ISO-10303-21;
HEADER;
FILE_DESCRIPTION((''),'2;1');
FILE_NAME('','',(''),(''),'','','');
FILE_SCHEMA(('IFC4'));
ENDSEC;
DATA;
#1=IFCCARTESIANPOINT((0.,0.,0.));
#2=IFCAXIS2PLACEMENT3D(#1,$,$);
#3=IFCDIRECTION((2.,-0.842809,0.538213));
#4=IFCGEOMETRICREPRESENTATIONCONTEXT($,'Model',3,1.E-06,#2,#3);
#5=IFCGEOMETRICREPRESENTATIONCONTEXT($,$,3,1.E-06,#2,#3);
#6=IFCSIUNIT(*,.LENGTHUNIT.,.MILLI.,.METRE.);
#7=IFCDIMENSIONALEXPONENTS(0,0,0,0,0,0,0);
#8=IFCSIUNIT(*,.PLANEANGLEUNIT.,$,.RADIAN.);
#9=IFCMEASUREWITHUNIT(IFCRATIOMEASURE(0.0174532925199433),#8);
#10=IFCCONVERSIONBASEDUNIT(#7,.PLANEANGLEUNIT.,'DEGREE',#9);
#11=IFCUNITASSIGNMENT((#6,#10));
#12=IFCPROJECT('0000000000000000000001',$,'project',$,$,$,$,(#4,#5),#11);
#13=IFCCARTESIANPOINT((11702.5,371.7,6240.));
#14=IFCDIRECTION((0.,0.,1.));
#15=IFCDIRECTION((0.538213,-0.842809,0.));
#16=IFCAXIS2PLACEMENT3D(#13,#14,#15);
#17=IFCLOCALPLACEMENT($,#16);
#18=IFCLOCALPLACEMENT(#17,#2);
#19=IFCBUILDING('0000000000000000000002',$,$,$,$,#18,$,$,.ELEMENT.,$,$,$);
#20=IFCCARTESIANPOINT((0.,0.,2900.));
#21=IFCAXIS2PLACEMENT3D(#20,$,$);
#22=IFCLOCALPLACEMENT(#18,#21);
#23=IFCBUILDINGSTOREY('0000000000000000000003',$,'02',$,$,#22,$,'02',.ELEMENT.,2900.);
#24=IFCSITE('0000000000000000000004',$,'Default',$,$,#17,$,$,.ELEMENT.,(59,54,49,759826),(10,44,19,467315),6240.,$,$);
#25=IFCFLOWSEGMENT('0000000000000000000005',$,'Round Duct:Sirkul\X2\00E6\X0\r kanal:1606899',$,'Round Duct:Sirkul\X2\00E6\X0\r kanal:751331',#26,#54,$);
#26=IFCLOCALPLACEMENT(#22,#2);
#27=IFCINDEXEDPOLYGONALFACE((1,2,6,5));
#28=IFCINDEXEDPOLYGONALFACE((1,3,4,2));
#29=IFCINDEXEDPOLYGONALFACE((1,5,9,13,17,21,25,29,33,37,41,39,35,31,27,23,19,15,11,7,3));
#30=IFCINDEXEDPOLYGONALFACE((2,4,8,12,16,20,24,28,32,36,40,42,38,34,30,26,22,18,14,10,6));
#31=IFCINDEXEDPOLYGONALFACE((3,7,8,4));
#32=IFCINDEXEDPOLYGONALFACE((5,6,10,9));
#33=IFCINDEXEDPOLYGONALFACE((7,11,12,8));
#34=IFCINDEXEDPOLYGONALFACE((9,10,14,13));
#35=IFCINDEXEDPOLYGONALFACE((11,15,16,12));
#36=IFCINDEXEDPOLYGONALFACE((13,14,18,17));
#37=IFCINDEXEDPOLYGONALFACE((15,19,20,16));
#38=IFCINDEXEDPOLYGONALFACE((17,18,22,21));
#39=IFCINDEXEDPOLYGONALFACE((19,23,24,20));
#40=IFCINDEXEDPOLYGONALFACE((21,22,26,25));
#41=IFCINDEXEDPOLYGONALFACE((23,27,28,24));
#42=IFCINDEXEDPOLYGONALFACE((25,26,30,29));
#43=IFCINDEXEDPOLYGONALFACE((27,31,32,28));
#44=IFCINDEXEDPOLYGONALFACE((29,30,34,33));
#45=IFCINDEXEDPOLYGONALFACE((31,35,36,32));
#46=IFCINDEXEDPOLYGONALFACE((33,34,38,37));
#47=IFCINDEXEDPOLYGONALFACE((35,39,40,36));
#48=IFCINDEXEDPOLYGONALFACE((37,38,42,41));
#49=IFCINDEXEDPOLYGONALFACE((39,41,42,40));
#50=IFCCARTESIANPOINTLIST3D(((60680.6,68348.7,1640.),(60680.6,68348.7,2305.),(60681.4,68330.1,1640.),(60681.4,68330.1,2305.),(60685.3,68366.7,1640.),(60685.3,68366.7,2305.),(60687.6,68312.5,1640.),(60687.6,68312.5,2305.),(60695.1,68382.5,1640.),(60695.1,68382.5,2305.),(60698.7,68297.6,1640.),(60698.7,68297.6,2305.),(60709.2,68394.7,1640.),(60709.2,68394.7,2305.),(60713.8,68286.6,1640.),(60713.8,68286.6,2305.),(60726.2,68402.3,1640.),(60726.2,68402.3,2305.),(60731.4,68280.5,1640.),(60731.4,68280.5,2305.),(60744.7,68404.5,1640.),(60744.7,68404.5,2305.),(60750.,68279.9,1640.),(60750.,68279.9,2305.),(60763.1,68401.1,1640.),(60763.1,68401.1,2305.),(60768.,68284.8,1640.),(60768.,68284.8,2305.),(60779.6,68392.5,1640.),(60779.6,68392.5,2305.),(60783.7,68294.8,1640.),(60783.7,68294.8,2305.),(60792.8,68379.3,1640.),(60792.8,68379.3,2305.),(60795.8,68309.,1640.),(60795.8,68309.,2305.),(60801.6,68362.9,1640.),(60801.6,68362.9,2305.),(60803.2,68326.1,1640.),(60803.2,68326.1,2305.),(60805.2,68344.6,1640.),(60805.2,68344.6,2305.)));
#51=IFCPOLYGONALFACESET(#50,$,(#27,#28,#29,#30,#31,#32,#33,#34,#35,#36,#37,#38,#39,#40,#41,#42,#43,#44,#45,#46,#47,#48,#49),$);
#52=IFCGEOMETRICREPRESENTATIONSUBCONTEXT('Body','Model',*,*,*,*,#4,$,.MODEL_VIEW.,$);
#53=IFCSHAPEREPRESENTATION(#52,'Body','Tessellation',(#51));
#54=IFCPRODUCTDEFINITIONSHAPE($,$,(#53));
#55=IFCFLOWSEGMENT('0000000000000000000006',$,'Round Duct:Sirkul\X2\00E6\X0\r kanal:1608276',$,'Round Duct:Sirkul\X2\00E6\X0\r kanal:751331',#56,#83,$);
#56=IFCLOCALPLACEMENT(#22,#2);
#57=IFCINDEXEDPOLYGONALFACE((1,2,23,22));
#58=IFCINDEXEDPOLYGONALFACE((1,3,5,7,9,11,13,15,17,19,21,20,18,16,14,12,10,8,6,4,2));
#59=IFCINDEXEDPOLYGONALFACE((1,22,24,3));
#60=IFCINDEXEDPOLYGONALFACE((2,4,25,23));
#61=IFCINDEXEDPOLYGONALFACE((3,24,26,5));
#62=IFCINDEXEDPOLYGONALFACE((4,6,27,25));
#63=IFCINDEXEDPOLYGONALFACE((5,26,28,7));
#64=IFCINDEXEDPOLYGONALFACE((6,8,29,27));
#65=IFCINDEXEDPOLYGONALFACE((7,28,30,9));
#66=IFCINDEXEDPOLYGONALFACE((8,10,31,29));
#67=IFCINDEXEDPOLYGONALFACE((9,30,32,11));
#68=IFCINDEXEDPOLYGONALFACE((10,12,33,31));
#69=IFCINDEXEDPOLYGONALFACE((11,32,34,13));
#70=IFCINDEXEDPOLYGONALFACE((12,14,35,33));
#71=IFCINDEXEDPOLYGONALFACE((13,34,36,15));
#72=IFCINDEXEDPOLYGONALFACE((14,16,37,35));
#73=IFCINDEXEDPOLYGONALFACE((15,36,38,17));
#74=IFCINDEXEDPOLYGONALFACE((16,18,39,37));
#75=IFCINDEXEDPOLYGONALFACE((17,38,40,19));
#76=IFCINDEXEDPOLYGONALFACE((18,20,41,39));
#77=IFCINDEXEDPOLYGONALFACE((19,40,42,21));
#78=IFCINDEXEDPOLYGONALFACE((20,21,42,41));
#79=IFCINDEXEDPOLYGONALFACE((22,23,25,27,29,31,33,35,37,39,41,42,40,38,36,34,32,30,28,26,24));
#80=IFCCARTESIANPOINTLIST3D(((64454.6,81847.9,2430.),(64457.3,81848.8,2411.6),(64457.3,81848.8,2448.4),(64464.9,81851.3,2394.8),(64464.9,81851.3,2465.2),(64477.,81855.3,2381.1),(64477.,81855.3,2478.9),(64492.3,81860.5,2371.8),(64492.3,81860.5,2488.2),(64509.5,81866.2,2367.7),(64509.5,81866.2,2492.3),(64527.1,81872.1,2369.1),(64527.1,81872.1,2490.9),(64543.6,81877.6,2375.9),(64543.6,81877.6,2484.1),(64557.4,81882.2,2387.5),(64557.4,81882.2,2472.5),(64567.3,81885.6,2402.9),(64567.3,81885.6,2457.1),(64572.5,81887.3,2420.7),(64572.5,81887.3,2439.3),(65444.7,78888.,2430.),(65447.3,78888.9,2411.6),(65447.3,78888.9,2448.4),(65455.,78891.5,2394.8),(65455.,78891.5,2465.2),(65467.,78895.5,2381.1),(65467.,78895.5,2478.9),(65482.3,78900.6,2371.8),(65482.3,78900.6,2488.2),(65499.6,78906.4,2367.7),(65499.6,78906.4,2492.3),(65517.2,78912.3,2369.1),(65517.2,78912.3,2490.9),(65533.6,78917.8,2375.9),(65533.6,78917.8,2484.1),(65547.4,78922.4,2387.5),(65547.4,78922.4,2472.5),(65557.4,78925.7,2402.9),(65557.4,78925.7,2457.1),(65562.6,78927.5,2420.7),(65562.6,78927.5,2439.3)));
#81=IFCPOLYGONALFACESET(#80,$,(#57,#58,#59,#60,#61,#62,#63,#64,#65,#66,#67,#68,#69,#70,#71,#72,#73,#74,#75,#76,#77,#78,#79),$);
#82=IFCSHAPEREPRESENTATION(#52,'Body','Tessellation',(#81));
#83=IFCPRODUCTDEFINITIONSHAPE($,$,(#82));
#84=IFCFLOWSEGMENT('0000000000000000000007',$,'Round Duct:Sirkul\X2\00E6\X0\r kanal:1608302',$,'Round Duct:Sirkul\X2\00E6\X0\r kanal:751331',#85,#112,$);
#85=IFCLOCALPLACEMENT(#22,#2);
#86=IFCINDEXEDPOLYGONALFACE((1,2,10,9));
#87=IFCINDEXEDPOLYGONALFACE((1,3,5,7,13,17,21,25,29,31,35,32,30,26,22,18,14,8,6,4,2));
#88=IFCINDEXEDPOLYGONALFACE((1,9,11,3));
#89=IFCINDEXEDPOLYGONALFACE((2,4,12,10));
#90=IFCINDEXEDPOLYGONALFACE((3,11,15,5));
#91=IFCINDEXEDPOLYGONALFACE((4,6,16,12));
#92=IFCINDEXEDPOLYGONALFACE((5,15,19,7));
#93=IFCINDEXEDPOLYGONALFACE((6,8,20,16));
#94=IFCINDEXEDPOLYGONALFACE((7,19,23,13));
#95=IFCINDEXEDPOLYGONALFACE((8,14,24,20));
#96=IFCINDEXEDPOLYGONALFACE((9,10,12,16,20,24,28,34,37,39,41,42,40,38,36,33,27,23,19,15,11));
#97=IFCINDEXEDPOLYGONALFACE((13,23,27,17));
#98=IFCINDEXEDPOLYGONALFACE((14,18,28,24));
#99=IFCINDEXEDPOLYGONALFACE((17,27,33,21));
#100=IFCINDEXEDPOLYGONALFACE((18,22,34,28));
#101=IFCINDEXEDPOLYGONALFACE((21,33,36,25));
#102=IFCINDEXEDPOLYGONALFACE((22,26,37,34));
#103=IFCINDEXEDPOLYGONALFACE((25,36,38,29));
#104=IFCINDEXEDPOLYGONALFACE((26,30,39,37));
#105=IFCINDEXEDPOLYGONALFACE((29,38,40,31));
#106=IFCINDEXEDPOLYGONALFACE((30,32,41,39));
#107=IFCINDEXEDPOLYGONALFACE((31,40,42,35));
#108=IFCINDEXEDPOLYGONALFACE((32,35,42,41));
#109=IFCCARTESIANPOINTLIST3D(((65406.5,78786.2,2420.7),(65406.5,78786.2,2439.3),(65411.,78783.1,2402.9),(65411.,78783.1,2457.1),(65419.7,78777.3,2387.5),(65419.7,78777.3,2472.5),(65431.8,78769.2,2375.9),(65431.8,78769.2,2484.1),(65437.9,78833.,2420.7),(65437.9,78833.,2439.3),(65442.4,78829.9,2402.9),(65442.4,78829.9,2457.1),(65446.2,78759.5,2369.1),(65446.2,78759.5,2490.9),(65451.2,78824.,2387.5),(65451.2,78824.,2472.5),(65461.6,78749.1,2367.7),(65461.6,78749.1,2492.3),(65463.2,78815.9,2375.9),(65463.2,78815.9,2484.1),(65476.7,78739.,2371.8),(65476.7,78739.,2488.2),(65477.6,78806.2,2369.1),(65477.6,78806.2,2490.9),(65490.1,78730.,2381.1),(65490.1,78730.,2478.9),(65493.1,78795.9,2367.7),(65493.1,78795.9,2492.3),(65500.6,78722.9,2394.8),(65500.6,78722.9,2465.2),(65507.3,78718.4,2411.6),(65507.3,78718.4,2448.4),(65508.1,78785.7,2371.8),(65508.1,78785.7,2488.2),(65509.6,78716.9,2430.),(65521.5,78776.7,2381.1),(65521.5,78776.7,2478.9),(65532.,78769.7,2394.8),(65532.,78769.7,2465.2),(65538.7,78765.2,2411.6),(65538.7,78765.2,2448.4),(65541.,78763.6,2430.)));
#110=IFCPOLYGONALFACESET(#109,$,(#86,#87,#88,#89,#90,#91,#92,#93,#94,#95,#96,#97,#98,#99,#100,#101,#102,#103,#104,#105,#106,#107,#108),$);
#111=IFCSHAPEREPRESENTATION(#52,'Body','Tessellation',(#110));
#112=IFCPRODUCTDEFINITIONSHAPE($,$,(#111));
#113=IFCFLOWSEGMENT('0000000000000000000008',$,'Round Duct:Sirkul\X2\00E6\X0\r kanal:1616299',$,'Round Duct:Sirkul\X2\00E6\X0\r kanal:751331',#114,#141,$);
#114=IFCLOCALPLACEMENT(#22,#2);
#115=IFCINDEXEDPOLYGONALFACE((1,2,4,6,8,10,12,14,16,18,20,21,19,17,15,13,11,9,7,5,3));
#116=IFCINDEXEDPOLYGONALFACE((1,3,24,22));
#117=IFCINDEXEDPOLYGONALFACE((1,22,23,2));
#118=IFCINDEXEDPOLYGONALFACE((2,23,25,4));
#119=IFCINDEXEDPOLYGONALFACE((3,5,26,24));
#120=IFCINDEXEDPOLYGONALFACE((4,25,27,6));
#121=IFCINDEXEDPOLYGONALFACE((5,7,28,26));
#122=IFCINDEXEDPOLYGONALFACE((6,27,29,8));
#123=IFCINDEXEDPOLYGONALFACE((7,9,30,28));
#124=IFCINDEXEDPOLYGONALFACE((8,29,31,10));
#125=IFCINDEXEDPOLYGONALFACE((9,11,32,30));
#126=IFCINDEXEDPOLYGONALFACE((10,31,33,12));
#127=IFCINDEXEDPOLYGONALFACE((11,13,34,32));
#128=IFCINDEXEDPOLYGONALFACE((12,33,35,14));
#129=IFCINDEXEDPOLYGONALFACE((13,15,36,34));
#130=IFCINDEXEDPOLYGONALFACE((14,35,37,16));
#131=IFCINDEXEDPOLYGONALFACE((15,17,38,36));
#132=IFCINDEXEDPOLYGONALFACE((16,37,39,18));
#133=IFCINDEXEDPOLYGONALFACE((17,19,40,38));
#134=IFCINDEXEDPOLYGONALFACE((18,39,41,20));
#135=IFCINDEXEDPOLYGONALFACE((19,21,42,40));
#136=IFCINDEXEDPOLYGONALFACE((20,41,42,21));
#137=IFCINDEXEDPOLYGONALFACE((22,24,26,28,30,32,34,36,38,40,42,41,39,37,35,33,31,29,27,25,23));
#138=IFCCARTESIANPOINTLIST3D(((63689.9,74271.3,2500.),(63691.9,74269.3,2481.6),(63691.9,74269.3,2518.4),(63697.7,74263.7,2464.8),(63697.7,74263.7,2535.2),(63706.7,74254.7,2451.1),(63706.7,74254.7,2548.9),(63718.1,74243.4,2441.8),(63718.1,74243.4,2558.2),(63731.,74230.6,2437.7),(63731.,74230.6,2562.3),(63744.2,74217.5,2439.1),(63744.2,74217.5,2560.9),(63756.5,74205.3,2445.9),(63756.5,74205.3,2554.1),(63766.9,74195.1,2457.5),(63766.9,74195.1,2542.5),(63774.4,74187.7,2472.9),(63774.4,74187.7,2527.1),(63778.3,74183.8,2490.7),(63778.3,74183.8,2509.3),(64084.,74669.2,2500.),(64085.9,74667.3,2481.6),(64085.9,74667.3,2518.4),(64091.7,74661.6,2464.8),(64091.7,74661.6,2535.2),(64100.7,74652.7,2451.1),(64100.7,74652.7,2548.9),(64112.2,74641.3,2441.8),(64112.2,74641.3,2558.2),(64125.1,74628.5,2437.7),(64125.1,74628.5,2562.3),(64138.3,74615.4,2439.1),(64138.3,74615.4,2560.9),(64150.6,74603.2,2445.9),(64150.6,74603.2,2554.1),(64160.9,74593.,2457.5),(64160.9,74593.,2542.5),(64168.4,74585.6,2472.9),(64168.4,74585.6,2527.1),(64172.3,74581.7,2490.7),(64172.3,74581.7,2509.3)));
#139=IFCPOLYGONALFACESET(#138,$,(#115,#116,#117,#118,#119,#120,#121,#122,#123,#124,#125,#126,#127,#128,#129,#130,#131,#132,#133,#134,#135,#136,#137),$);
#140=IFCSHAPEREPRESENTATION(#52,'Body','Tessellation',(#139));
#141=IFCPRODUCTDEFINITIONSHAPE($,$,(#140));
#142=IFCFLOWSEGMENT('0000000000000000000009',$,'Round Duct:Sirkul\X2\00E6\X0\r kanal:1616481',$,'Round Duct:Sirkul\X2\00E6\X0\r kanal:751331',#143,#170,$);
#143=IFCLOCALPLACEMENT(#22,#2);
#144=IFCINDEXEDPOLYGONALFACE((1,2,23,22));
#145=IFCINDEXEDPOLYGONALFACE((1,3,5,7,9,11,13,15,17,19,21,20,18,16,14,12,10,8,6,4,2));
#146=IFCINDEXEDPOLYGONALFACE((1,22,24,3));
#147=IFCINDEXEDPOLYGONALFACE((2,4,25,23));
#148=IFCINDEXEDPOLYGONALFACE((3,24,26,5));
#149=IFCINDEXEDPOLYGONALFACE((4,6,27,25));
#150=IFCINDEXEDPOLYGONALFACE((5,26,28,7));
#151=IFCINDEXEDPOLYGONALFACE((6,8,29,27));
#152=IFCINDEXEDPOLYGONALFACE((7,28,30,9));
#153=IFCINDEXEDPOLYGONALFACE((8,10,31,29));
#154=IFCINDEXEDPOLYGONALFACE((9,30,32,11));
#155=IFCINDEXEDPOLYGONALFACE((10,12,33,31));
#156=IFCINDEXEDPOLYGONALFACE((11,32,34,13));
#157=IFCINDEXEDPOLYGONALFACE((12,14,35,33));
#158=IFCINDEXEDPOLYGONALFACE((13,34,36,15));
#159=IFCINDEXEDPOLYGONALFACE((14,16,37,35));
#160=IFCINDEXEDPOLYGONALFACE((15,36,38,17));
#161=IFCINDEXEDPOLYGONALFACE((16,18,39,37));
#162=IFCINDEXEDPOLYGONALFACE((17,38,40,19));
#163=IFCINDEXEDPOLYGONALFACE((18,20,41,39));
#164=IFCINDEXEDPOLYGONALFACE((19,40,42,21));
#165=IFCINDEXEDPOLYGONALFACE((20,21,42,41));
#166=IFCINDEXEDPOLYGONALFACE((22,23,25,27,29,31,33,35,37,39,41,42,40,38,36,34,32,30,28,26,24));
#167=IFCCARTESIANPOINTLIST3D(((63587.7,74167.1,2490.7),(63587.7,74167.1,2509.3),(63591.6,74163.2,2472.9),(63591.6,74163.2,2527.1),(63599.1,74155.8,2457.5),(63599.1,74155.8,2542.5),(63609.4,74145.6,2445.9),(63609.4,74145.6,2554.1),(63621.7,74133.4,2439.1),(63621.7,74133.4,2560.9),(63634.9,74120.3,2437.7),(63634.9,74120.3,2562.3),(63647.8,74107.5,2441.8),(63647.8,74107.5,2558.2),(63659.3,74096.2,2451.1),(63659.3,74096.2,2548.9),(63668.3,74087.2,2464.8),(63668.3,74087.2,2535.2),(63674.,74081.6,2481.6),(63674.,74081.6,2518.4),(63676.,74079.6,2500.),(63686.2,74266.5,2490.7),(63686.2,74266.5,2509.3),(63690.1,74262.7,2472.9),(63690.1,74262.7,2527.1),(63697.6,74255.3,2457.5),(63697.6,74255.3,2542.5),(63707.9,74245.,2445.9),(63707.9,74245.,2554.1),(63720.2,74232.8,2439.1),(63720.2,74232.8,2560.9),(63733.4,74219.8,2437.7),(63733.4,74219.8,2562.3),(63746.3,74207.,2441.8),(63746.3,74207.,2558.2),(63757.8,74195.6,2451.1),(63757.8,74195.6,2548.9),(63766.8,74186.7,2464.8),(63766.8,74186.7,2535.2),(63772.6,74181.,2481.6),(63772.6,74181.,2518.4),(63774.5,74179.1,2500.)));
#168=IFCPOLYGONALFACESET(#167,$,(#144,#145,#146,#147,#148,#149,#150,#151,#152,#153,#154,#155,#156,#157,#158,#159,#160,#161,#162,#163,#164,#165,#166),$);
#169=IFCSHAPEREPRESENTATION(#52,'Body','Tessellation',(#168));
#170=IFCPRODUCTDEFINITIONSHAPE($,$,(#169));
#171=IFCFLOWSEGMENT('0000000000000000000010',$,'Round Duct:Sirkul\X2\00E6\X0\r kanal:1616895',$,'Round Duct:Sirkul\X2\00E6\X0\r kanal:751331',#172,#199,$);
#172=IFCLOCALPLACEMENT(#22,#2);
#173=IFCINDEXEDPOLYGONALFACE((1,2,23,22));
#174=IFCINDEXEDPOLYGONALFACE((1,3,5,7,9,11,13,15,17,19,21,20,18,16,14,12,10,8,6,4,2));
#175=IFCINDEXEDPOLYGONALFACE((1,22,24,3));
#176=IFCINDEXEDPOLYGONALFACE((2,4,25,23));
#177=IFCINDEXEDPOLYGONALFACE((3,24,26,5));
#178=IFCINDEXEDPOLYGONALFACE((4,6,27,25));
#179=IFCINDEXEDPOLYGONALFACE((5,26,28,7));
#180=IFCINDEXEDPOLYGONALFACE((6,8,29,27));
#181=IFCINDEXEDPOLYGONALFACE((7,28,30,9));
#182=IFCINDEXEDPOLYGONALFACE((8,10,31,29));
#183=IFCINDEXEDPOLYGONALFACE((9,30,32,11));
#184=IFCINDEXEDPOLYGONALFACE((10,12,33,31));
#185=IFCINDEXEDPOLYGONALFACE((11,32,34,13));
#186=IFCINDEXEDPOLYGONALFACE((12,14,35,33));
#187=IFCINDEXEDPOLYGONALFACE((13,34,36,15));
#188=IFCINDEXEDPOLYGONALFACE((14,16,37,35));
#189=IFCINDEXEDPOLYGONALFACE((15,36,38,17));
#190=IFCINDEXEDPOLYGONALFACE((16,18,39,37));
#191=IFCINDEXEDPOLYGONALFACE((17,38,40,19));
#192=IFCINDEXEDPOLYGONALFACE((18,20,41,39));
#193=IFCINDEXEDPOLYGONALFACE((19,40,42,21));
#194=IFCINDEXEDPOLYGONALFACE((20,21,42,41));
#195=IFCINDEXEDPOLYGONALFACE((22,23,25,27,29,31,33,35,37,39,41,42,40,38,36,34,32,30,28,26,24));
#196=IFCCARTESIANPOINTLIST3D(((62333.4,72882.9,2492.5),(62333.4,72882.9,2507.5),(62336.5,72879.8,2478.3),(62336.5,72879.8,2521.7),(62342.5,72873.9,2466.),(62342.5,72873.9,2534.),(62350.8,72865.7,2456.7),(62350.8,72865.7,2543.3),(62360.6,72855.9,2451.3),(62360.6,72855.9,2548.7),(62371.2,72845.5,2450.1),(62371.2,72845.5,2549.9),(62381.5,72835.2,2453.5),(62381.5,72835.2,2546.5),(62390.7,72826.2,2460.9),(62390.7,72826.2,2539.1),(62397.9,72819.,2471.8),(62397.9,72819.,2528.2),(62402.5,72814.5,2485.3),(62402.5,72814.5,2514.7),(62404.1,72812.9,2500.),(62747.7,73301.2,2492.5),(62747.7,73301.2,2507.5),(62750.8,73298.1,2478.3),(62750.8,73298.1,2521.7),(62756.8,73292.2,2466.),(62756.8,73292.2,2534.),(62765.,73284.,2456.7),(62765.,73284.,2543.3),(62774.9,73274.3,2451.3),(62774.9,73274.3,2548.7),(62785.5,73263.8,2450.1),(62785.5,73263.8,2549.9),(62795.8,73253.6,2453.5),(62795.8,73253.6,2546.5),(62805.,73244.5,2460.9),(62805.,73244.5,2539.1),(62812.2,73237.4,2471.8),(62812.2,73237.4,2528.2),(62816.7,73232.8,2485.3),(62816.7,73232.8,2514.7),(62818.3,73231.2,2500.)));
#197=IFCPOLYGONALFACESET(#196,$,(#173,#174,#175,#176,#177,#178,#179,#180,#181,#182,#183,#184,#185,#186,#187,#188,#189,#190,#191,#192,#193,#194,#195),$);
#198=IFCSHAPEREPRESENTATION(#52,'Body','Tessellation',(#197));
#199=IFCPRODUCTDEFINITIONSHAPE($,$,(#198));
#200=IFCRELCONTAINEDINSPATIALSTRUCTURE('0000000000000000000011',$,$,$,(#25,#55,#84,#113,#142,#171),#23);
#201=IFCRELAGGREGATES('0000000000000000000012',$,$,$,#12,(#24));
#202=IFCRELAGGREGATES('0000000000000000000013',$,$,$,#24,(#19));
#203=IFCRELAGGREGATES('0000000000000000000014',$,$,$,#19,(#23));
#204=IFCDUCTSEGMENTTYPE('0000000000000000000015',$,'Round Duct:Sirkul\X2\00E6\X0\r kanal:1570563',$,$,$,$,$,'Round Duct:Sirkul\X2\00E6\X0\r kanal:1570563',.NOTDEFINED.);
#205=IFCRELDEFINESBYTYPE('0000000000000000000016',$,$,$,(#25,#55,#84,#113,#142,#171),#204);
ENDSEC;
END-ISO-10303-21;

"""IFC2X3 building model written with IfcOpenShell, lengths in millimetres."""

from ifc_helpers import new_model, entity, si_unit, converted_unit, direction, frame, frame_2d, origin, origin_2d_with_axis, place, context, subcontext, project, spatial, circle, extrude, type_object, element, save


model = new_model("IFC2X3")

# Units and contexts
model_context = context("Model", 3, precision=1e-06, world=origin(), true_north=direction((2.0, -0.842809, 0.538213)))
context_of_model = context(None, 3, precision=1e-06, world=origin(), true_north=direction((2.0, -0.842809, 0.538213)))
body_context = subcontext(model_context, "Body", "Model", "MODEL_VIEW")
ifc_project = project(units=[si_unit("LENGTHUNIT", "METRE", prefix="MILLI"), converted_unit("PLANEANGLEUNIT", "DEGREE", entity("IfcRatioMeasure", 0.0174532925199433), si_unit("PLANEANGLEUNIT", "RADIAN"), dimensions=[0, 0, 0, 0, 0, 0, 0])], contexts=[model_context, context_of_model])

# Site, building, storey
site_placement = place(None, frame((11702.5, 371.7, 6240.0), z_axis=(0.0, 0.0, 1.0), x_axis=(0.538213, -0.842809, 0.0)))
site = spatial("IfcSite", under=ifc_project, at=site_placement, Name="Default", CompositionType="ELEMENT", RefLatitude=(59, 54, 49, 759826), RefLongitude=(10, 44, 19, 467315), RefElevation=6240.0)
building_placement = place(site_placement, origin())
building = spatial("IfcBuilding", under=site, at=building_placement, CompositionType="ELEMENT")
storey_placement = place(building_placement, frame((0.0, 0.0, 2900.0)))
storey = spatial("IfcBuildingStorey", under=building, at=storey_placement, Name="02", LongName="02", CompositionType="ELEMENT", Elevation=2900.0)

# Flow segments
duct_segment_type = type_object("IfcDuctSegmentType", Name="Round Duct:Sirkulær kanal:1570563", ElementType="Round Duct:Sirkulær kanal:1570563", PredefinedType="NOTDEFINED")
flow_segment_1_placement = place(storey_placement, origin())
element("IfcFlowSegment", 1, at=flow_segment_1_placement, inside=storey, type_object=duct_segment_type, Name="Round Duct:Sirkulær kanal:1606899", ObjectType="Round Duct:Sirkulær kanal:751331", context=body_context, shape_type="SweptSolid", body=[
    extrude(circle(Radius=62.5, at=origin_2d_with_axis()), frame((60742.7, 68342.0, 1640.0), z_axis=(0.0, 0.0, 1.0), x_axis=(-0.703661, -0.710536, 0.0)), (0.0, 0.0, 1.0), 665.0),
])
flow_segment_2_placement = place(storey_placement, origin())
element("IfcFlowSegment", 2, at=flow_segment_2_placement, inside=storey, type_object=duct_segment_type, Name="Round Duct:Sirkulær kanal:1608276", ObjectType="Round Duct:Sirkulær kanal:751331", context=body_context, shape_type="SweptSolid", body=[
    extrude(circle(Radius=62.5, at=origin_2d_with_axis()), frame((64513.9, 81867.7, 2430.0), z_axis=(0.317224, -0.948351, 0.0), x_axis=(-0.948351, -0.317224, 0.0)), (0.0, 0.0, 1.0), 3121.0),
])
flow_segment_3_placement = place(storey_placement, origin())
element("IfcFlowSegment", 3, at=flow_segment_3_placement, inside=storey, type_object=duct_segment_type, Name="Round Duct:Sirkulær kanal:1608302", ObjectType="Round Duct:Sirkulær kanal:751331", context=body_context, shape_type="SweptSolid", body=[
    extrude(circle(Radius=62.5, at=origin_2d_with_axis()), frame((65457.8, 78751.7, 2430.0), z_axis=(0.557892, 0.829913, 0.0), x_axis=(0.829913, -0.557892, 0.0)), (0.0, 0.0, 1.0), 56.3),
])
flow_segment_4_placement = place(storey_placement, origin())
element("IfcFlowSegment", 4, at=flow_segment_4_placement, inside=storey, type_object=duct_segment_type, Name="Round Duct:Sirkulær kanal:1616299", ObjectType="Round Duct:Sirkulær kanal:751331", context=body_context, shape_type="SweptSolid", body=[
    extrude(circle(Radius=62.5, at=origin_2d_with_axis()), frame((63734.3, 74227.3, 2500.0), z_axis=(0.703643, 0.710554, 0.0), x_axis=(-0.710554, 0.703643, 0.0)), (0.0, 0.0, 1.0), 560.0),
])
flow_segment_5_placement = place(storey_placement, origin())
element("IfcFlowSegment", 5, at=flow_segment_5_placement, inside=storey, type_object=duct_segment_type, Name="Round Duct:Sirkulær kanal:1616481", ObjectType="Round Duct:Sirkulær kanal:751331", context=body_context, shape_type="SweptSolid", body=[
    extrude(circle(Radius=62.5, at=origin_2d_with_axis()), frame((63631.6, 74123.6, 2500.0), z_axis=(0.703643, 0.710554, 0.0), x_axis=(0.710554, -0.703643, 0.0)), (0.0, 0.0, 1.0), 140.0),
])
flow_segment_6_placement = place(storey_placement, origin())
element("IfcFlowSegment", 6, at=flow_segment_6_placement, inside=storey, type_object=duct_segment_type, Name="Round Duct:Sirkulær kanal:1616895", ObjectType="Round Duct:Sirkulær kanal:751331", context=body_context, shape_type="SweptSolid", body=[
    extrude(circle(Radius=50.0, at=frame_2d((0.0, 0.0), x_axis=(1.0, 0.0))), frame((62368.5, 72848.1, 2500.0), z_axis=(0.703643, 0.710554, 0.0), x_axis=(0.710554, -0.703643, 0.0)), (0.0, 0.0, 1.0), 588.8),
])

save(model, "model.ifc")
